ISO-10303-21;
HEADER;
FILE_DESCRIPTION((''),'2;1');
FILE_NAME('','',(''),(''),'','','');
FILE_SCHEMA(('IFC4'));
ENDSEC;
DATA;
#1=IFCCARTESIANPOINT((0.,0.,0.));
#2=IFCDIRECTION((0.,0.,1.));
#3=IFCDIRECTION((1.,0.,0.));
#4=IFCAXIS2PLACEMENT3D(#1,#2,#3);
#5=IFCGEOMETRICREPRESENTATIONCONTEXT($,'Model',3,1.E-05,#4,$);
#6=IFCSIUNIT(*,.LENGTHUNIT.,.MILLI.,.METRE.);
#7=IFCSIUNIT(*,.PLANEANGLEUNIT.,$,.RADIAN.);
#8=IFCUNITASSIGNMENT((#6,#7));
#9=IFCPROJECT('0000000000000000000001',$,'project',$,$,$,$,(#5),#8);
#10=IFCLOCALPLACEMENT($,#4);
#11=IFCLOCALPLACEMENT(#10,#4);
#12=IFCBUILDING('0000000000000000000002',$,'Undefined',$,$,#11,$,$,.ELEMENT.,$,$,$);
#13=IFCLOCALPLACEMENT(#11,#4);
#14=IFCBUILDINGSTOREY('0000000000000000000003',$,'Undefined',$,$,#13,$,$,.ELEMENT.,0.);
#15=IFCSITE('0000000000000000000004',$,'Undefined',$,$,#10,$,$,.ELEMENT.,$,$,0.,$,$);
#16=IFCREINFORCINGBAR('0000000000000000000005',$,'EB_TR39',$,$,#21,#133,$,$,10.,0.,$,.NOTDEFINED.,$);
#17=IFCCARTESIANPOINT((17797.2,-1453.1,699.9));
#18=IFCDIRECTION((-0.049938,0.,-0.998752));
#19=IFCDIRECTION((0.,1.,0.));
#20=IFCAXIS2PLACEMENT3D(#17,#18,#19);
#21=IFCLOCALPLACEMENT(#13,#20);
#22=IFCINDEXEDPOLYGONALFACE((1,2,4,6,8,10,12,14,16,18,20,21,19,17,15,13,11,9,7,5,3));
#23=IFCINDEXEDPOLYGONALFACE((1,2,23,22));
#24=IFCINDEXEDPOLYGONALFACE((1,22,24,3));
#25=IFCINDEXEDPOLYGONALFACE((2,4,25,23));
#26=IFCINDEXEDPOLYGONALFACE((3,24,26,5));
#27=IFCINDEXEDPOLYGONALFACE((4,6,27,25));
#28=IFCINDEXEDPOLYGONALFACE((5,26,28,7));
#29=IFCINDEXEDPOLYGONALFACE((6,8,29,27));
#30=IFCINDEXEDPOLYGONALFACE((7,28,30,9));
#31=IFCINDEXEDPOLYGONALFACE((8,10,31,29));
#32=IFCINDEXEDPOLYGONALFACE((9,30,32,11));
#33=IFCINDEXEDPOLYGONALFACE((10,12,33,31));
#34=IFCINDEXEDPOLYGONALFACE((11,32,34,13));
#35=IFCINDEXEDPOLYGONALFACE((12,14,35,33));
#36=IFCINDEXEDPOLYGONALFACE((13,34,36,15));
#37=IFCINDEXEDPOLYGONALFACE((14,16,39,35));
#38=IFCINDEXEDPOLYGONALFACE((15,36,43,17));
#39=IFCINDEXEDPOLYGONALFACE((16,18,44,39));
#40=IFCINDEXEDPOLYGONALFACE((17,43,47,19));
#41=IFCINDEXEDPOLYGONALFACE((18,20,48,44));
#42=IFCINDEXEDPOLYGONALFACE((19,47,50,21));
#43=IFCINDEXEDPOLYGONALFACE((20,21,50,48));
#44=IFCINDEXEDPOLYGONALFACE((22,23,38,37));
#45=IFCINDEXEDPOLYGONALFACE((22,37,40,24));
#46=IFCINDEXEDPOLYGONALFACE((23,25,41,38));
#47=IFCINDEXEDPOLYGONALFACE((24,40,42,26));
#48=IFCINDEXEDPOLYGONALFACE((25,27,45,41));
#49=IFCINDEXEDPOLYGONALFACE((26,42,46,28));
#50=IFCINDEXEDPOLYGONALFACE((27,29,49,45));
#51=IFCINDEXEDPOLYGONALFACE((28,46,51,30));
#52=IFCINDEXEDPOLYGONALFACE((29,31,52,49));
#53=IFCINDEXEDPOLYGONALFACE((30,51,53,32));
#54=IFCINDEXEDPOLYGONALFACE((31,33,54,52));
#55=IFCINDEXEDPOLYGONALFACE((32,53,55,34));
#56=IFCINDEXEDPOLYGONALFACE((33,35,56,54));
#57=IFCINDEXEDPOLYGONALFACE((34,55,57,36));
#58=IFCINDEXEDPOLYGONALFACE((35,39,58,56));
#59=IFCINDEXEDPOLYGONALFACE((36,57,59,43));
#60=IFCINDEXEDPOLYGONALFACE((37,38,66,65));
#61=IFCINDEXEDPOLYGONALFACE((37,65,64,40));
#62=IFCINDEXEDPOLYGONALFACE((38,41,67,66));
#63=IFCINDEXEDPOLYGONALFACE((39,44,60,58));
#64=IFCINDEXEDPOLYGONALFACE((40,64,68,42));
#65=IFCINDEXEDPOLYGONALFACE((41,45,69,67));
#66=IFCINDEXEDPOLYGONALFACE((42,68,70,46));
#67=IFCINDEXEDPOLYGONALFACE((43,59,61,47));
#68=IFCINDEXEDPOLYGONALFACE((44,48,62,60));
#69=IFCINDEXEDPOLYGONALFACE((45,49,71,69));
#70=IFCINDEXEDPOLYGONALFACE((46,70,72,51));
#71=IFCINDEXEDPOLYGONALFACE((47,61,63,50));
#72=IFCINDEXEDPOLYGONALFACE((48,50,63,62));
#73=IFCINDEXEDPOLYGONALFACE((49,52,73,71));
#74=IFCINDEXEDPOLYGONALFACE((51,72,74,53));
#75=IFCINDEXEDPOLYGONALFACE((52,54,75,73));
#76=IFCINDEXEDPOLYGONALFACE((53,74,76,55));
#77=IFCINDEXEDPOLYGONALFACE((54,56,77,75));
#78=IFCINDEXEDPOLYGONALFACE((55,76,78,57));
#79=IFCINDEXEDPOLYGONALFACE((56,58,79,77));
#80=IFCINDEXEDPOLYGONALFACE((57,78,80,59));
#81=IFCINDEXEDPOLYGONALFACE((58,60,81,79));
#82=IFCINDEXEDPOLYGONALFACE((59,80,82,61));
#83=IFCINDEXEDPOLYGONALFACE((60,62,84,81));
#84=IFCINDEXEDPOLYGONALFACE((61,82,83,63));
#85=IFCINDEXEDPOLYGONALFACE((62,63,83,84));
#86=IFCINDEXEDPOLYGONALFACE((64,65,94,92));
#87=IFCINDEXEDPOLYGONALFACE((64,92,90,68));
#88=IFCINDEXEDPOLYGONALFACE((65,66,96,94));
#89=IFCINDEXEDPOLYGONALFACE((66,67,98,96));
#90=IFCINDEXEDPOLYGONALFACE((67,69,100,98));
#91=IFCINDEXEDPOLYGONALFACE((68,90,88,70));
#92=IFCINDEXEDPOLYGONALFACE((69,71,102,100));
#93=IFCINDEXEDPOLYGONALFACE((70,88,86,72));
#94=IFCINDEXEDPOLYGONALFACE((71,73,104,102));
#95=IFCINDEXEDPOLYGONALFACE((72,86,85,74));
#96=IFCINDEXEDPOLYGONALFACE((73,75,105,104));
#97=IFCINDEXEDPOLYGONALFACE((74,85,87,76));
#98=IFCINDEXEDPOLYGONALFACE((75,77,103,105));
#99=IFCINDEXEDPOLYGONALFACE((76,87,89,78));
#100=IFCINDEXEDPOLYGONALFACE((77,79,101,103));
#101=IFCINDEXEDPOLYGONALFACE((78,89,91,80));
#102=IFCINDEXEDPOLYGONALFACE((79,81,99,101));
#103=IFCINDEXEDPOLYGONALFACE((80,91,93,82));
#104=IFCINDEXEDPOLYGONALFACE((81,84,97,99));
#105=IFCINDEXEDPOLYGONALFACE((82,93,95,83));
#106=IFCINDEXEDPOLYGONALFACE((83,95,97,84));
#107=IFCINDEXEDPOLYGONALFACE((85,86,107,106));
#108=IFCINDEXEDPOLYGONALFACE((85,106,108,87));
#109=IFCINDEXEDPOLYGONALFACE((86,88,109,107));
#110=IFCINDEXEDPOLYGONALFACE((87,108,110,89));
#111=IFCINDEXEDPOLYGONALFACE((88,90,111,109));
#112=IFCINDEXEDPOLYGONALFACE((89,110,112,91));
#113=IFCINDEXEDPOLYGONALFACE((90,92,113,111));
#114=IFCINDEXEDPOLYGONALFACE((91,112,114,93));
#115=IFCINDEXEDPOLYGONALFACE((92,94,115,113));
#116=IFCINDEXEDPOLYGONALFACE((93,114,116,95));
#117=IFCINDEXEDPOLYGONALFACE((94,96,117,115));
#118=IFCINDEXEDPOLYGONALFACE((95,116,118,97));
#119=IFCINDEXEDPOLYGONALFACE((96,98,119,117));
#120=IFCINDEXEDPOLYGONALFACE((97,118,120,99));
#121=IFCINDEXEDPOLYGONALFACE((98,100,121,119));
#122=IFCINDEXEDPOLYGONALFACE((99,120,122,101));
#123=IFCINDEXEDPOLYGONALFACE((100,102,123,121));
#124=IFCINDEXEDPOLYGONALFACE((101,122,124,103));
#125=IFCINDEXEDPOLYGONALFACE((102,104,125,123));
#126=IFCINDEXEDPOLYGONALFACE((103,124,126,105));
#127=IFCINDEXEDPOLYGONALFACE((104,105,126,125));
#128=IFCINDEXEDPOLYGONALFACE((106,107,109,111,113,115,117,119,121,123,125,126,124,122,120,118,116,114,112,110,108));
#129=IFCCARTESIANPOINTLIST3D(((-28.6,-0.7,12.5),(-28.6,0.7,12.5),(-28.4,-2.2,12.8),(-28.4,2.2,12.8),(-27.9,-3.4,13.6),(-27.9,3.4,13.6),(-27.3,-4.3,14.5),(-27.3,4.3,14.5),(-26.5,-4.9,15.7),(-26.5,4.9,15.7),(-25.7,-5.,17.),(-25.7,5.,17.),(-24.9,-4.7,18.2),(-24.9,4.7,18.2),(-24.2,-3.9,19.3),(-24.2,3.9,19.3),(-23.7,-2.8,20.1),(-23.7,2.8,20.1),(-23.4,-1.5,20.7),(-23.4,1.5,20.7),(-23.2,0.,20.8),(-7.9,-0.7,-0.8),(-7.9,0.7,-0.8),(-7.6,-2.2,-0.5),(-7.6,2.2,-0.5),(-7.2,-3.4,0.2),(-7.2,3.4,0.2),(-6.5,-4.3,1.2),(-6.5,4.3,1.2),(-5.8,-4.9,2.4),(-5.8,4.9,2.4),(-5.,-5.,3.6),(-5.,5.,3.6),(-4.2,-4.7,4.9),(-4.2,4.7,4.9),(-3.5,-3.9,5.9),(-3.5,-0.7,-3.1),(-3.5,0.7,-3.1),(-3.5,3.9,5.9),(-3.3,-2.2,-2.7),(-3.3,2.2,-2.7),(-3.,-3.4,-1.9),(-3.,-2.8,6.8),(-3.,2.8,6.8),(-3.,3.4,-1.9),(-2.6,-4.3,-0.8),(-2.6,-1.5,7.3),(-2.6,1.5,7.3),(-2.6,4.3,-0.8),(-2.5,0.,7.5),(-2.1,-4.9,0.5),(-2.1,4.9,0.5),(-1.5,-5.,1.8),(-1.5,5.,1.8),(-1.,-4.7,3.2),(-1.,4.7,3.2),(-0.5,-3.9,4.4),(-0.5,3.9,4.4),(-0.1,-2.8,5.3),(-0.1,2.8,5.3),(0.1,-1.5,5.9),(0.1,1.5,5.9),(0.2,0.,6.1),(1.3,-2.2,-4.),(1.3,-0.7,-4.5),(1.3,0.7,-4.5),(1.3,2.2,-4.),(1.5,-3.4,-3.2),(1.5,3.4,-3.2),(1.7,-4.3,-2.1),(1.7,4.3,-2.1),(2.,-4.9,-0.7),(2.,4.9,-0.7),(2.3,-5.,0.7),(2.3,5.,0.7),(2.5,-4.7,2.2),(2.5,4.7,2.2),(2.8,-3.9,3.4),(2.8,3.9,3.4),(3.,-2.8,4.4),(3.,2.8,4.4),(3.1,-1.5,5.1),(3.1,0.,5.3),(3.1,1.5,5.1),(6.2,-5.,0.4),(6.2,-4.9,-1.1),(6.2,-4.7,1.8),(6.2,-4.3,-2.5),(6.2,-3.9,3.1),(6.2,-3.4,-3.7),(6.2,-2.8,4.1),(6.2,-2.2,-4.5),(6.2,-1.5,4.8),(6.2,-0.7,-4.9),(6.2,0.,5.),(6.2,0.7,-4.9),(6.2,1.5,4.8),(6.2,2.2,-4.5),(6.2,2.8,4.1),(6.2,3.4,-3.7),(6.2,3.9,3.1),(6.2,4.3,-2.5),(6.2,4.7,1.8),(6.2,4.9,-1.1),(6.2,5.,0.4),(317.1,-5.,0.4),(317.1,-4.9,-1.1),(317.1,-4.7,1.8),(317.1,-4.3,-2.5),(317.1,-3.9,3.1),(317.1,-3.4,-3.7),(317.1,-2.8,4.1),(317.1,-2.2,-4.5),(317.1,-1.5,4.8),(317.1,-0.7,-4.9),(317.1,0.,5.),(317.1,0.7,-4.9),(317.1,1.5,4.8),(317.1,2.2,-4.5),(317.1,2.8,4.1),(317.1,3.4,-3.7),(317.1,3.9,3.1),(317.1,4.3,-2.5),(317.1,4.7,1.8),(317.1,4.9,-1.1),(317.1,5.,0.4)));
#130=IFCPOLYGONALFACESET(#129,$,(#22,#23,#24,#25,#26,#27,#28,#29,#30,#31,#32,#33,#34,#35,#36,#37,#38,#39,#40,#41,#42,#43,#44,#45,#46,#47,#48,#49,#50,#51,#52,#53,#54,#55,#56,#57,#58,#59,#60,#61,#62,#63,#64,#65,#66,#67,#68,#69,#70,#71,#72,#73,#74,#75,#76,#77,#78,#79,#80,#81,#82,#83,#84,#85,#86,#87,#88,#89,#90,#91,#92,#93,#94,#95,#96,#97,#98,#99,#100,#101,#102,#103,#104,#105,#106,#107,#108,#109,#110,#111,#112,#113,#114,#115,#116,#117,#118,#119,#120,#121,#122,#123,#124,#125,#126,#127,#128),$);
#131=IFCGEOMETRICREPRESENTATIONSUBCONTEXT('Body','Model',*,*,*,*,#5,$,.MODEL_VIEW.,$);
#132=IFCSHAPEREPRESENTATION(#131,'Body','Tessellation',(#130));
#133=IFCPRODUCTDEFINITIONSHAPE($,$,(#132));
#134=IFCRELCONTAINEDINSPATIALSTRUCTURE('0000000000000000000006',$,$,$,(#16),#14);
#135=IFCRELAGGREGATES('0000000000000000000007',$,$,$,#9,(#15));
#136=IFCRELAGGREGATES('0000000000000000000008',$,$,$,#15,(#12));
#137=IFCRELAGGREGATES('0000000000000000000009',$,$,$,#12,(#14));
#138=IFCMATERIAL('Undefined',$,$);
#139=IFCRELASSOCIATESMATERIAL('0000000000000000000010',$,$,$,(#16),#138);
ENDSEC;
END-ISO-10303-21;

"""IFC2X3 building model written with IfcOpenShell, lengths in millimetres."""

from ifc_helpers import new_model, entity, si_unit, frame, origin_with_axes, place, context, subcontext, project, spatial, source, transform, mapped, material, element, save


model = new_model("IFC2X3")

# Units and contexts
model_context = context("Model", 3, precision=1e-05, world=origin_with_axes())
body_context = subcontext(model_context, "Body", "Model", "MODEL_VIEW")
ifc_project = project(units=[si_unit("LENGTHUNIT", "METRE", prefix="MILLI"), si_unit("PLANEANGLEUNIT", "RADIAN")], contexts=[model_context])

# Site, building, storey
site_placement = place(None, origin_with_axes())
site = spatial("IfcSite", under=ifc_project, at=site_placement, Name="Undefined", CompositionType="ELEMENT", RefElevation=0.0)
building_placement = place(site_placement, origin_with_axes())
building = spatial("IfcBuilding", under=site, at=building_placement, Name="Undefined", CompositionType="ELEMENT")
storey_placement = place(building_placement, origin_with_axes())
storey = spatial("IfcBuildingStorey", under=building, at=storey_placement, Name="Undefined", CompositionType="ELEMENT", Elevation=0.0)

# Reinforcing bar
ifc_material_1 = material(Name="Undefined")
shared_shape_1 = source(origin_with_axes(), body_context, "Body", "AdvancedSweptSolid", [
    entity("IfcSweptDiskSolid", entity("IfcCompositeCurve", [entity("IfcCompositeCurveSegment", "CONTINUOUS", True, entity("IfcTrimmedCurve", entity("IfcLine", entity("IfcCartesianPoint", [0.0, 0.0, 0.0]), entity("IfcVector", entity("IfcDirection", [0.841694, 0.0, -0.539955]), 1.0)), [entity("IfcParameterValue", 0.0)], [entity("IfcParameterValue", 24.65374)], True, "PARAMETER")), entity("IfcCompositeCurveSegment", "CONTINUOUS", True, entity("IfcTrimmedCurve", entity("IfcCircle", entity("IfcAxis2Placement3D", entity("IfcCartesianPoint", [32.1, 0.0, 4.4]), entity("IfcDirection", [0.0, -1.0, 0.0]), entity("IfcDirection", [-0.539955, 0.0, -0.841694])), 21.0), [entity("IfcParameterValue", 0.0)], [entity("IfcParameterValue", 0.570383)], True, "PARAMETER")), entity("IfcCompositeCurveSegment", "DISCONTINUOUS", True, entity("IfcTrimmedCurve", entity("IfcLine", entity("IfcCartesianPoint", [32.1, 0.0, -16.6]), entity("IfcVector", entity("IfcDirection", [1.0, 0.0, 0.0]), 1.0)), [entity("IfcParameterValue", 0.0)], [entity("IfcParameterValue", 310.940714)], True, "PARAMETER"))], False), 5.0, None, 0.0, 336.2),
])
reinforcing_bar_1_placement = place(storey_placement, frame((17797.2, -1453.1, 699.9), z_axis=(-0.049938, 0.0, -0.998752), x_axis=(0.0, 1.0, 0.0)))
element("IfcReinforcingBar", 1, at=reinforcing_bar_1_placement, inside=storey, material=ifc_material_1, Name="EB_TR39", BarRole="NOTDEFINED", CrossSectionArea=0.0, NominalDiameter=10.0, context=body_context, shape_type="MappedRepresentation", body=[
    mapped(shared_shape_1, transform((-25.9, 0.0, 16.6))),
])

save(model, "model.ifc")
